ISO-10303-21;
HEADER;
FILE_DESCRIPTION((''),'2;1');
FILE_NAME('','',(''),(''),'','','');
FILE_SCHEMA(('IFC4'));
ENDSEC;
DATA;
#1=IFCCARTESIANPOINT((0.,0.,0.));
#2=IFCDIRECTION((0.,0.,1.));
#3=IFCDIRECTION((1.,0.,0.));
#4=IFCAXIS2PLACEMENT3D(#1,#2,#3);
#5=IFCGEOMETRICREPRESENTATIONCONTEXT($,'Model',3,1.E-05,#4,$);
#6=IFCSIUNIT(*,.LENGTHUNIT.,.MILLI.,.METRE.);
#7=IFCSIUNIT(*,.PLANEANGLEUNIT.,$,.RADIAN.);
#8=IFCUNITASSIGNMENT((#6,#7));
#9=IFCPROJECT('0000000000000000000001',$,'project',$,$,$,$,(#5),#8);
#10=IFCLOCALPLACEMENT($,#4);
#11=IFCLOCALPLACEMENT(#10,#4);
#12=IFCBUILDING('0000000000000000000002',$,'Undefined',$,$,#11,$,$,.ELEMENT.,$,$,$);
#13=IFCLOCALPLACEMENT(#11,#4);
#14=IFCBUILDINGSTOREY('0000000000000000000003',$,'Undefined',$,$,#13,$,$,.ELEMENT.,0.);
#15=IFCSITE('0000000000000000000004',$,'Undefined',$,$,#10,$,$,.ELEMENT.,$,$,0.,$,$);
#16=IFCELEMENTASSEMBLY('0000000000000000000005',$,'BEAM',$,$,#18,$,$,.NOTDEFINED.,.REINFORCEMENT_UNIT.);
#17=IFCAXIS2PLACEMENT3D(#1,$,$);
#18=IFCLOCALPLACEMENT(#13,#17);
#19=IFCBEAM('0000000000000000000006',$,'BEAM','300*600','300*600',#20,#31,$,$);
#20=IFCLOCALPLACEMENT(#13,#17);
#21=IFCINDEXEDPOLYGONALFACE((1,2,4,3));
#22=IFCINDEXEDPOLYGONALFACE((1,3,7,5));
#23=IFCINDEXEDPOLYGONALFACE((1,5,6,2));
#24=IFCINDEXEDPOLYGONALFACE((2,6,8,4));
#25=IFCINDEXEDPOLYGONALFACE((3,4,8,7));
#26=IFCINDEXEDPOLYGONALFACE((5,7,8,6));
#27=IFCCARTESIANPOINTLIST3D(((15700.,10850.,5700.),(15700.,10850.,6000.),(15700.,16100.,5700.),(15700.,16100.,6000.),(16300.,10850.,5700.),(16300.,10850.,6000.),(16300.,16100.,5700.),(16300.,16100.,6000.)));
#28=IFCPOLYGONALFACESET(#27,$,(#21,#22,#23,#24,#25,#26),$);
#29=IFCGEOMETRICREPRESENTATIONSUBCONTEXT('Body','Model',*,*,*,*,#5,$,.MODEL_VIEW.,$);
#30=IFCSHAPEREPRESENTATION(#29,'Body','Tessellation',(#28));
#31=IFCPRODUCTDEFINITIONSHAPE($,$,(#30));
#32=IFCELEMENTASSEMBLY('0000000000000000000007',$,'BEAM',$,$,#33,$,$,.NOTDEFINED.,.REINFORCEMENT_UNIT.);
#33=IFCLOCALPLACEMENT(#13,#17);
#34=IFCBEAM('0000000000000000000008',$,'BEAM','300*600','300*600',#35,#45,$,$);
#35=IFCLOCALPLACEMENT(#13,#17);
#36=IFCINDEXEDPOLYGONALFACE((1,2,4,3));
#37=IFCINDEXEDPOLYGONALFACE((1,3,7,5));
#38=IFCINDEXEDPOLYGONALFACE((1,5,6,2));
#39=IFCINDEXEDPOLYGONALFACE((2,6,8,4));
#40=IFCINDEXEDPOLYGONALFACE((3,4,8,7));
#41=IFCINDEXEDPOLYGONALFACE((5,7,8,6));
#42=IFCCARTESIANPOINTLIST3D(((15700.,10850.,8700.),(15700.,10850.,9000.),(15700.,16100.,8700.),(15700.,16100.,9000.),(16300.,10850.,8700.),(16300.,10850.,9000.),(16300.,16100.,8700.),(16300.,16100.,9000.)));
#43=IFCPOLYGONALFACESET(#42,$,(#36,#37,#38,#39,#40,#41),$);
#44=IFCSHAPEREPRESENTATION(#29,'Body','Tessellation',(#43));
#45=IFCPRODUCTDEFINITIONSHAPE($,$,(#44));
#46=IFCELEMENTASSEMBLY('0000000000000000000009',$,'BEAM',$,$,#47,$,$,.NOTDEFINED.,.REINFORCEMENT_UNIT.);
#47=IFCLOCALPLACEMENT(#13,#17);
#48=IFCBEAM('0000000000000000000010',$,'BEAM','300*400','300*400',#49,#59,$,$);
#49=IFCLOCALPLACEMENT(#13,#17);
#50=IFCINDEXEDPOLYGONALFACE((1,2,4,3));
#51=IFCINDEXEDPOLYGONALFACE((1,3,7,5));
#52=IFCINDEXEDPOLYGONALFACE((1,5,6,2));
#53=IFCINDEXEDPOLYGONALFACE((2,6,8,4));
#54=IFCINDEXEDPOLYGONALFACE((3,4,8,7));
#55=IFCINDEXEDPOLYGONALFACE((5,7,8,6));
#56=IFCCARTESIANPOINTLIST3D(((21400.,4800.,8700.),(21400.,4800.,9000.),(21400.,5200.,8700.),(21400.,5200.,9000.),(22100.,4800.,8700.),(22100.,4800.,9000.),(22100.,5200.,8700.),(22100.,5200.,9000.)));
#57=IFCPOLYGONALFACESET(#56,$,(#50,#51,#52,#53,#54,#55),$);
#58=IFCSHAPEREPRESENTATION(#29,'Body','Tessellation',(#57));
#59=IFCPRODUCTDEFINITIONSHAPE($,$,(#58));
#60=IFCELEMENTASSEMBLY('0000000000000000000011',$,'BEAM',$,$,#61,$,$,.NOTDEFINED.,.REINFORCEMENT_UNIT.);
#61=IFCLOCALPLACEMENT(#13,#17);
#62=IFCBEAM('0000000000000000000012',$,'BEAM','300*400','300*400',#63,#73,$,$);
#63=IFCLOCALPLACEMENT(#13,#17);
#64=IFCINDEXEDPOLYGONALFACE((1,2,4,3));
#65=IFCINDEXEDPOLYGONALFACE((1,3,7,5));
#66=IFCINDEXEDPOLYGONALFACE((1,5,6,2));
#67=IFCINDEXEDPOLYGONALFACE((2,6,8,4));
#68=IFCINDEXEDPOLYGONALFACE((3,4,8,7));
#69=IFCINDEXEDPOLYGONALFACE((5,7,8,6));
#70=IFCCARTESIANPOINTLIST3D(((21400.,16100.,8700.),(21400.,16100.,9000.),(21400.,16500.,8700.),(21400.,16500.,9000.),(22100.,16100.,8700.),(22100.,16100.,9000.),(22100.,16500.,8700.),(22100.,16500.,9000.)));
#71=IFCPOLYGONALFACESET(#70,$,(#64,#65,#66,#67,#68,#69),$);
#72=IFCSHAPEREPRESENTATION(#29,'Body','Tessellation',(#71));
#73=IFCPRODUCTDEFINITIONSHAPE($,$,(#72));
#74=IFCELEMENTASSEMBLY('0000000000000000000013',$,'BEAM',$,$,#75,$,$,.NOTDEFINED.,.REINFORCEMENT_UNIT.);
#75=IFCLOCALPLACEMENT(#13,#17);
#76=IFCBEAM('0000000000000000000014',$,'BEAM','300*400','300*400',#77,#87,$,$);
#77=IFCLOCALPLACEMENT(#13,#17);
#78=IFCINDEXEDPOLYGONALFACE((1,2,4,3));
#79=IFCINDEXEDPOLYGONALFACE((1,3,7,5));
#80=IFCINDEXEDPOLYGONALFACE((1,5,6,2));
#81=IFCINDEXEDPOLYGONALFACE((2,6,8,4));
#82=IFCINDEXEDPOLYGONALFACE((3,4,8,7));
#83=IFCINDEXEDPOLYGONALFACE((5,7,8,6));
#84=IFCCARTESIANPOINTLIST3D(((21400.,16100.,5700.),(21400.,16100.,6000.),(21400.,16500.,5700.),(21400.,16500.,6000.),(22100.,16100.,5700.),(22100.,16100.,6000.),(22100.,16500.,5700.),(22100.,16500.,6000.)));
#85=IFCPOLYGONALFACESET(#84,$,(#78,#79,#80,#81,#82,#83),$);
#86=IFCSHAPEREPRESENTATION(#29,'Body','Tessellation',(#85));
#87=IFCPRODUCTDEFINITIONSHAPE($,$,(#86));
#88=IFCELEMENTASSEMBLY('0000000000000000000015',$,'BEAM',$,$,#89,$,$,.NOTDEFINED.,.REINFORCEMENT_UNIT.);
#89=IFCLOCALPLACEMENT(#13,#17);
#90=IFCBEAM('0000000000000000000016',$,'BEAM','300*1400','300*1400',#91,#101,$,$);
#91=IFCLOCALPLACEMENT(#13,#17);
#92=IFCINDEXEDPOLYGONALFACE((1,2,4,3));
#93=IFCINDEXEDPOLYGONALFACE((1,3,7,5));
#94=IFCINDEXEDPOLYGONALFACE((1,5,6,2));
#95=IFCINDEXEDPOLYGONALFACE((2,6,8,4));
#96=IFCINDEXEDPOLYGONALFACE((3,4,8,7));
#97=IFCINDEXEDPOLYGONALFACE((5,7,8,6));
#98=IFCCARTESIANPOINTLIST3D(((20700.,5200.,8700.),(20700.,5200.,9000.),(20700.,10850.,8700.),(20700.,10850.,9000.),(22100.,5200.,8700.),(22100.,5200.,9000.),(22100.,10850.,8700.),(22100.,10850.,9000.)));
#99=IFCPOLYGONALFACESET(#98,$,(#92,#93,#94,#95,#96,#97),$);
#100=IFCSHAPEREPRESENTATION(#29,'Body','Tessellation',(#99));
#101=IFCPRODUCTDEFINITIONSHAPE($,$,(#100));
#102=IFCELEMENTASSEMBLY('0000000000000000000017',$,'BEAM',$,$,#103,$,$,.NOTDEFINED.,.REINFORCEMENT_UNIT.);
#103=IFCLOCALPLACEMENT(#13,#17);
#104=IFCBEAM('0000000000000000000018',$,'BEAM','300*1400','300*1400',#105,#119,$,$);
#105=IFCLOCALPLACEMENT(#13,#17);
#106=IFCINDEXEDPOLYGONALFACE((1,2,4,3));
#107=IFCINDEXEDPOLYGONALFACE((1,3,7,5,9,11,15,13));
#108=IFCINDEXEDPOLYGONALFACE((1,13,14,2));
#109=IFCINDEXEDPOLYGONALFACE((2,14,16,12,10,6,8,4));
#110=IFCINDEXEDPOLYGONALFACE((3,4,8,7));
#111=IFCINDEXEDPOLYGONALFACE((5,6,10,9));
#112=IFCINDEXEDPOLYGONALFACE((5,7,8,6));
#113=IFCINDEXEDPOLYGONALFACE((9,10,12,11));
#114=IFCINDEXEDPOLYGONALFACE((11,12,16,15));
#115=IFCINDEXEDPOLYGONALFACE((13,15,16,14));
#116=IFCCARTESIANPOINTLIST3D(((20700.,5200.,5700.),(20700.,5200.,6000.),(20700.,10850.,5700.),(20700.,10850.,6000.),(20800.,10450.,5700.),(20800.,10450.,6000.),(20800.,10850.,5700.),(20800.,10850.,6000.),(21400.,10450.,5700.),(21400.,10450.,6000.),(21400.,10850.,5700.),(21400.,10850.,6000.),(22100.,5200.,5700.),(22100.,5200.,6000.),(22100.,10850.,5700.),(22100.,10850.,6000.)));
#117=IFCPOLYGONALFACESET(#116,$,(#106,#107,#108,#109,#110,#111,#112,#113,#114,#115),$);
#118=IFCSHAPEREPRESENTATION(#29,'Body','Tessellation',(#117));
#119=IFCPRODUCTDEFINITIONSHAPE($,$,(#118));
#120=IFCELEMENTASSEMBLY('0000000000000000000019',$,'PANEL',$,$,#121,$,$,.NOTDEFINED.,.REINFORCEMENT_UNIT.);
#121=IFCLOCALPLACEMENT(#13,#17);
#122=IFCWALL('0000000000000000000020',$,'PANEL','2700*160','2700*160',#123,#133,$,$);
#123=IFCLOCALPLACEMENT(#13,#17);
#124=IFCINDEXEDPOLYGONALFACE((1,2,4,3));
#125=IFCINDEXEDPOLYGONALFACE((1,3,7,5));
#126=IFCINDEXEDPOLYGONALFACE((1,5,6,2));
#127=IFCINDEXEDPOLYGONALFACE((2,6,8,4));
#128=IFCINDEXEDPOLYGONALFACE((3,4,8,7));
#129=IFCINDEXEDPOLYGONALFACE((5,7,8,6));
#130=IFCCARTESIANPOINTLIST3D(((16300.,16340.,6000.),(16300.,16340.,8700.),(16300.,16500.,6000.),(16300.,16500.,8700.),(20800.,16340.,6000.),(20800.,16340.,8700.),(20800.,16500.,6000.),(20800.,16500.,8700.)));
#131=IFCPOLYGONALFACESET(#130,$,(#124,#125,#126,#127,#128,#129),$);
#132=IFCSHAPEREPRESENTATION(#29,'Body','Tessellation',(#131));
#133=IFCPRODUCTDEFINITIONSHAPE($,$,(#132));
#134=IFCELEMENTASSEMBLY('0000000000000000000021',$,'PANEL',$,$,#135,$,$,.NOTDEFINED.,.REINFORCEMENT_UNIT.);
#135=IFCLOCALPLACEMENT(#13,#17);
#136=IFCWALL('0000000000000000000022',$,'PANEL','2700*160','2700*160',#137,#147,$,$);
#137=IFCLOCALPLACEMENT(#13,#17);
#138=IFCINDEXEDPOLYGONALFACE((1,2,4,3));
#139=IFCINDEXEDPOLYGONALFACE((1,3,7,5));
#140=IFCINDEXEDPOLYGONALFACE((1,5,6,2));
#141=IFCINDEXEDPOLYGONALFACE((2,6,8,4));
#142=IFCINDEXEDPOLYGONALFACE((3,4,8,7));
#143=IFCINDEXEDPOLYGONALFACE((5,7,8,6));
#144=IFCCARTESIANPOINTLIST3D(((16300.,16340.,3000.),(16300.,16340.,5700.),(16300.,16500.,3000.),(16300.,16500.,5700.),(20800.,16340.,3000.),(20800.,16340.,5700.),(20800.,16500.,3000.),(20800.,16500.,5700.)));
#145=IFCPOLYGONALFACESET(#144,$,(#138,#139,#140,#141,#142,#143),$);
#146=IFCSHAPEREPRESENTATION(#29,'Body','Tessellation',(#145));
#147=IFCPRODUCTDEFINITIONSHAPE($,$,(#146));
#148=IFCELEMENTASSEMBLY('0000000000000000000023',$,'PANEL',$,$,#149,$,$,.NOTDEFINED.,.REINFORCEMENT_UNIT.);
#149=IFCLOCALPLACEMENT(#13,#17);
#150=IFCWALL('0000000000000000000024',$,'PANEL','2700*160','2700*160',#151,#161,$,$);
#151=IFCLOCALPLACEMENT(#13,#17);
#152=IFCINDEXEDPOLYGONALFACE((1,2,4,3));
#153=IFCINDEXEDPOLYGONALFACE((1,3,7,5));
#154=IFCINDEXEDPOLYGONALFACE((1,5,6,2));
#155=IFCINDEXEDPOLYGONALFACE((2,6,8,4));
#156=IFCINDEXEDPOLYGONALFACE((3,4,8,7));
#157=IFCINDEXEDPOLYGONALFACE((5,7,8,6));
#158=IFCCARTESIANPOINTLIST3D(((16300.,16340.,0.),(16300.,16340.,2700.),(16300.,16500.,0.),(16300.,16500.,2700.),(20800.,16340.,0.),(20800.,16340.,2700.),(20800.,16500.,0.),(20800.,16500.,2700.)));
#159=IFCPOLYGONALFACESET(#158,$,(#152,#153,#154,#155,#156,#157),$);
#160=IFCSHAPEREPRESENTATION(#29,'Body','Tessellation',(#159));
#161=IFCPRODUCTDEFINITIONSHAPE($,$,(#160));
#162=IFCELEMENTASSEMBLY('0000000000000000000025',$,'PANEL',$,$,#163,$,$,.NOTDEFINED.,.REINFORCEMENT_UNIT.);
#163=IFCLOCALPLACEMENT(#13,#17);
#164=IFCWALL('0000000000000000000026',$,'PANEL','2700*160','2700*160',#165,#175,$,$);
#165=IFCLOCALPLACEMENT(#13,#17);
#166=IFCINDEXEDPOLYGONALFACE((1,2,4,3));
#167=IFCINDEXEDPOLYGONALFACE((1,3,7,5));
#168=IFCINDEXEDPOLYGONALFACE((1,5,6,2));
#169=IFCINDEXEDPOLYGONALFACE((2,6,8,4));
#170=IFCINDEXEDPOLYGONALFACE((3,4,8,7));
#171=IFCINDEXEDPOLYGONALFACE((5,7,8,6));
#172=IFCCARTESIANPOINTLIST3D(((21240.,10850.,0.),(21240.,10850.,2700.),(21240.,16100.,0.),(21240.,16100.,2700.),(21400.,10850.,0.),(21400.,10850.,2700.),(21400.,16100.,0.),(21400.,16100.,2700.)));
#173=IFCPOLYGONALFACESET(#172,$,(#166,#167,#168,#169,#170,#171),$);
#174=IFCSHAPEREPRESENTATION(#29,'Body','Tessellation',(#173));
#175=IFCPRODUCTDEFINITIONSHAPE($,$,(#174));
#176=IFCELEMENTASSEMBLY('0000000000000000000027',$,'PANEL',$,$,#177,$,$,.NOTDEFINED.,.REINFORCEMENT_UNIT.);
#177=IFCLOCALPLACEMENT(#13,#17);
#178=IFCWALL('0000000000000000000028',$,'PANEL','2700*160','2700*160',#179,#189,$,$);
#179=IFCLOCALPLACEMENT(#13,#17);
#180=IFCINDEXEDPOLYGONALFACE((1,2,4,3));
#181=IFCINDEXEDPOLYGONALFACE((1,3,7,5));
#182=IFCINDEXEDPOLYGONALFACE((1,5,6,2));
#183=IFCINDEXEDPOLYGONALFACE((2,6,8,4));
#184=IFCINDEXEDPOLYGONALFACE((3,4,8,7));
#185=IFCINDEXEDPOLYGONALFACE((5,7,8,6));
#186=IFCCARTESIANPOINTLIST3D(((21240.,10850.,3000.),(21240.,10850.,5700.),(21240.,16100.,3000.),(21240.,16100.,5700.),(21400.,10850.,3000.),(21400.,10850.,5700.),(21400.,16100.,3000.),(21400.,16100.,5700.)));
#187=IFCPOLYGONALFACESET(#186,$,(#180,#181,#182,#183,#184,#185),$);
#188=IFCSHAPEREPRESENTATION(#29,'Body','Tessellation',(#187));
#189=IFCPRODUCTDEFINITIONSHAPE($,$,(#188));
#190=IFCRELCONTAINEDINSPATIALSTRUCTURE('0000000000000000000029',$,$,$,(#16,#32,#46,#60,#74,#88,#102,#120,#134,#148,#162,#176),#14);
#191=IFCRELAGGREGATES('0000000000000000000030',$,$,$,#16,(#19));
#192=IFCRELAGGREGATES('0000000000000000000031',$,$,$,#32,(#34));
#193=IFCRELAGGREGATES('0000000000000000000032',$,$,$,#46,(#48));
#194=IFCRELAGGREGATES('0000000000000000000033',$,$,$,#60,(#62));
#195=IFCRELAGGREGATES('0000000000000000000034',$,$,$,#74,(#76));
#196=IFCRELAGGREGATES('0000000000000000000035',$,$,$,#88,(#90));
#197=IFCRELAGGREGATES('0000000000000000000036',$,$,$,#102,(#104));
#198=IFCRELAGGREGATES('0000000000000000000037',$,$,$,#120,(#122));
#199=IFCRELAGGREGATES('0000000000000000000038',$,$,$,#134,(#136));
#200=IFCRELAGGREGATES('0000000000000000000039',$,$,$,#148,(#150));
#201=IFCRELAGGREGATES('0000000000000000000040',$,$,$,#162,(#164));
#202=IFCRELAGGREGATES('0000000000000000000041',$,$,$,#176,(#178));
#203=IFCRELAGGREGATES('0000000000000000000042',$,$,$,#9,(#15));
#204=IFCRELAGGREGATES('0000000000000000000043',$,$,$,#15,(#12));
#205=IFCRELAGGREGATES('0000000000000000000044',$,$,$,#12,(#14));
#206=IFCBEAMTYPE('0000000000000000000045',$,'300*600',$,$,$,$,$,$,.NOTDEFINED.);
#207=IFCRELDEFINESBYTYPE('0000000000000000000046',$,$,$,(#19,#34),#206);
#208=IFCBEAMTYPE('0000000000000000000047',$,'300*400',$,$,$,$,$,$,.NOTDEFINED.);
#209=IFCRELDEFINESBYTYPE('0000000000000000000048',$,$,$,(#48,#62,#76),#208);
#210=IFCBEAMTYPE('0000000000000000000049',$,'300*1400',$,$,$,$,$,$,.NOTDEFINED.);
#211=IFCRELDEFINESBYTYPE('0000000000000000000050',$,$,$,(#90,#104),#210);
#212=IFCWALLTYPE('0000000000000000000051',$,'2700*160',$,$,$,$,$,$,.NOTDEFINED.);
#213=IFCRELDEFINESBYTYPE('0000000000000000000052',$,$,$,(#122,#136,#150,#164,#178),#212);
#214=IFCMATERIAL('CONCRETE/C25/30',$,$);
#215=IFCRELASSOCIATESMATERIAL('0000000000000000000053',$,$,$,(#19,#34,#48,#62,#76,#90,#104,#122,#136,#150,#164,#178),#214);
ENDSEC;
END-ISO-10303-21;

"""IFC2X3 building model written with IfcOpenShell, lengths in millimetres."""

from ifc_helpers import new_model, si_unit, frame, frame_2d, origin_with_axes, origin_2d_with_axis, place, context, subcontext, project, spatial, rectangle, extrude, boolean, material, type_object, element, aggregate, save


model = new_model("IFC2X3")

# Units and contexts
model_context = context("Model", 3, precision=1e-05, world=origin_with_axes())
body_context = subcontext(model_context, "Body", "Model", "MODEL_VIEW")
ifc_project = project(units=[si_unit("LENGTHUNIT", "METRE", prefix="MILLI"), si_unit("PLANEANGLEUNIT", "RADIAN")], contexts=[model_context])

# Site, building, storey
site_placement = place(None, origin_with_axes())
site = spatial("IfcSite", under=ifc_project, at=site_placement, Name="Undefined", CompositionType="ELEMENT", RefElevation=0.0)
building_placement = place(site_placement, origin_with_axes())
building = spatial("IfcBuilding", under=site, at=building_placement, Name="Undefined", CompositionType="ELEMENT")
storey_placement = place(building_placement, origin_with_axes())
storey = spatial("IfcBuildingStorey", under=building, at=storey_placement, Name="Undefined", CompositionType="ELEMENT", Elevation=0.0)

# Shared definitions
ifc_material = material(Name="CONCRETE/C25/30")

# Element assemblies, beams
beam_type_1 = type_object("IfcBeamType", Name="300*600", PredefinedType="NOTDEFINED")
assembly_1_placement = place(storey_placement, origin_with_axes())
assembly_1 = element("IfcElementAssembly", 1, at=assembly_1_placement, inside=storey, Name="BEAM", AssemblyPlace="NOTDEFINED", PredefinedType="REINFORCEMENT_UNIT")
beam_1_placement = place(assembly_1_placement, frame((16000.0, 16300.0, 5850.0), z_axis=(0.0, 0.0, 1.0), x_axis=(0.0, -1.0, 0.0)))
beam_1 = element("IfcBeam", 2, at=beam_1_placement, type_object=beam_type_1, material=ifc_material, Name="BEAM", Description="300*600", ObjectType="300*600", context=body_context, shape_type="SweptSolid", body=[
    extrude(rectangle(XDim=600.0, YDim=300.0, at=origin_2d_with_axis()), frame((5450.0, 0.0, 0.0), z_axis=(-1.0, 0.0, 0.0), x_axis=(0.0, -1.0, 0.0)), (0.0, 0.0, 1.0), 5250.0),
])
aggregate(assembly_1, [beam_1])
assembly_2_placement = place(storey_placement, origin_with_axes())
assembly_2 = element("IfcElementAssembly", 3, at=assembly_2_placement, inside=storey, Name="BEAM", AssemblyPlace="NOTDEFINED", PredefinedType="REINFORCEMENT_UNIT")
beam_2_placement = place(assembly_2_placement, frame((16000.0, 16300.0, 8850.0), z_axis=(0.0, 0.0, 1.0), x_axis=(0.0, -1.0, 0.0)))
beam_2 = element("IfcBeam", 4, at=beam_2_placement, type_object=beam_type_1, material=ifc_material, Name="BEAM", Description="300*600", ObjectType="300*600", context=body_context, shape_type="SweptSolid", body=[
    extrude(rectangle(XDim=600.0, YDim=300.0, at=origin_2d_with_axis()), frame((5450.0, 0.0, 0.0), z_axis=(-1.0, 0.0, 0.0), x_axis=(0.0, -1.0, 0.0)), (0.0, 0.0, 1.0), 5250.0),
])
aggregate(assembly_2, [beam_2])
beam_type_2 = type_object("IfcBeamType", Name="300*400", PredefinedType="NOTDEFINED")
assembly_3_placement = place(storey_placement, origin_with_axes())
assembly_3 = element("IfcElementAssembly", 5, at=assembly_3_placement, inside=storey, Name="BEAM", AssemblyPlace="NOTDEFINED", PredefinedType="REINFORCEMENT_UNIT")
beam_3_placement = place(assembly_3_placement, frame((21400.0, 5000.0, 8850.0), z_axis=(0.0, 0.0, 1.0), x_axis=(1.0, 0.0, 0.0)))
beam_3 = element("IfcBeam", 6, at=beam_3_placement, type_object=beam_type_2, material=ifc_material, Name="BEAM", Description="300*400", ObjectType="300*400", context=body_context, shape_type="SweptSolid", body=[
    extrude(rectangle(XDim=400.0, YDim=300.0, at=origin_2d_with_axis()), frame((700.0, 0.0, 0.0), z_axis=(-1.0, 0.0, 0.0), x_axis=(0.0, -1.0, 0.0)), (0.0, 0.0, 1.0), 700.0),
])
aggregate(assembly_3, [beam_3])
assembly_4_placement = place(storey_placement, origin_with_axes())
assembly_4 = element("IfcElementAssembly", 7, at=assembly_4_placement, inside=storey, Name="BEAM", AssemblyPlace="NOTDEFINED", PredefinedType="REINFORCEMENT_UNIT")
beam_4_placement = place(assembly_4_placement, frame((21400.0, 16300.0, 8850.0), z_axis=(0.0, 0.0, 1.0), x_axis=(1.0, 0.0, 0.0)))
beam_4 = element("IfcBeam", 8, at=beam_4_placement, type_object=beam_type_2, material=ifc_material, Name="BEAM", Description="300*400", ObjectType="300*400", context=body_context, shape_type="SweptSolid", body=[
    extrude(rectangle(XDim=400.0, YDim=300.0, at=origin_2d_with_axis()), frame((700.0, 0.0, 0.0), z_axis=(-1.0, 0.0, 0.0), x_axis=(0.0, -1.0, 0.0)), (0.0, 0.0, 1.0), 700.0),
])
aggregate(assembly_4, [beam_4])
assembly_5_placement = place(storey_placement, origin_with_axes())
assembly_5 = element("IfcElementAssembly", 9, at=assembly_5_placement, inside=storey, Name="BEAM", AssemblyPlace="NOTDEFINED", PredefinedType="REINFORCEMENT_UNIT")
beam_5_placement = place(assembly_5_placement, frame((21400.0, 16300.0, 5850.0), z_axis=(0.0, 0.0, 1.0), x_axis=(1.0, 0.0, 0.0)))
beam_5 = element("IfcBeam", 10, at=beam_5_placement, type_object=beam_type_2, material=ifc_material, Name="BEAM", Description="300*400", ObjectType="300*400", context=body_context, shape_type="SweptSolid", body=[
    extrude(rectangle(XDim=400.0, YDim=300.0, at=origin_2d_with_axis()), frame((700.0, 0.0, 0.0), z_axis=(-1.0, 0.0, 0.0), x_axis=(0.0, -1.0, 0.0)), (0.0, 0.0, 1.0), 700.0),
])
aggregate(assembly_5, [beam_5])
assembly_6_placement = place(storey_placement, origin_with_axes())
assembly_6 = element("IfcElementAssembly", 11, at=assembly_6_placement, inside=storey, Name="BEAM", AssemblyPlace="NOTDEFINED", PredefinedType="REINFORCEMENT_UNIT")
beam_type_3 = type_object("IfcBeamType", Name="300*1400", PredefinedType="NOTDEFINED")
beam_6_placement = place(assembly_6_placement, frame((21400.0, 5200.0, 8850.0), z_axis=(0.0, 0.0, 1.0), x_axis=(0.0, 1.0, 0.0)))
beam_6 = element("IfcBeam", 12, at=beam_6_placement, type_object=beam_type_3, material=ifc_material, Name="BEAM", Description="300*1400", ObjectType="300*1400", context=body_context, shape_type="SweptSolid", body=[
    extrude(rectangle(XDim=1400.0, YDim=300.0, at=origin_2d_with_axis()), frame((5650.0, 0.0, 0.0), z_axis=(-1.0, 0.0, 0.0), x_axis=(0.0, -1.0, 0.0)), (0.0, 0.0, 1.0), 5650.0),
])
aggregate(assembly_6, [beam_6])
assembly_7_placement = place(storey_placement, origin_with_axes())
assembly_7 = element("IfcElementAssembly", 13, at=assembly_7_placement, inside=storey, Name="BEAM", AssemblyPlace="NOTDEFINED", PredefinedType="REINFORCEMENT_UNIT")
beam_7_placement = place(assembly_7_placement, frame((21400.0, 5200.0, 5850.0), z_axis=(0.0, 0.0, 1.0), x_axis=(0.0, 1.0, 0.0)))
beam_7 = element("IfcBeam", 14, at=beam_7_placement, type_object=beam_type_3, material=ifc_material, Name="BEAM", Description="300*1400", ObjectType="300*1400", context=body_context, shape_type="CSG", body=[
    boolean("DIFFERENCE", extrude(rectangle(XDim=1400.0, YDim=300.0, at=origin_2d_with_axis()), frame((5650.0, 0.0, 0.0), z_axis=(-1.0, 0.0, 0.0), x_axis=(0.0, -1.0, 0.0)), (0.0, 0.0, 1.0), 5650.0), extrude(rectangle(XDim=600.0, YDim=400.0, at=origin_2d_with_axis()), frame((5450.0, 300.0, 150.0), z_axis=(0.0, 0.0, -1.0), x_axis=(0.0, 1.0, 0.0)), (0.0, 0.0, 1.0), 3000.0)),
])
aggregate(assembly_7, [beam_7])

# Element assemblies, walls
assembly_8_placement = place(storey_placement, origin_with_axes())
assembly_8 = element("IfcElementAssembly", 15, at=assembly_8_placement, inside=storey, Name="PANEL", AssemblyPlace="NOTDEFINED", PredefinedType="REINFORCEMENT_UNIT")
wall_type = type_object("IfcWallType", Name="2700*160", PredefinedType="NOTDEFINED")
wall_1_placement = place(assembly_8_placement, frame((16300.0, 16420.0, 6000.0), z_axis=(0.0, 0.0, 1.0), x_axis=(1.0, 0.0, 0.0)))
wall_1 = element("IfcWall", 16, at=wall_1_placement, type_object=wall_type, material=ifc_material, Name="PANEL", Description="2700*160", ObjectType="2700*160", context=body_context, shape_type="SweptSolid", body=[
    extrude(rectangle(XDim=4500.0, YDim=160.0, at=frame_2d((0.0, 2250.0), x_axis=(0.0, -1.0))), frame((0.0, 0.0, 0.0), z_axis=(0.0, 0.0, 1.0), x_axis=(0.0, -1.0, 0.0)), (0.0, 0.0, 1.0), 2700.0),
])
aggregate(assembly_8, [wall_1])
assembly_9_placement = place(storey_placement, origin_with_axes())
assembly_9 = element("IfcElementAssembly", 17, at=assembly_9_placement, inside=storey, Name="PANEL", AssemblyPlace="NOTDEFINED", PredefinedType="REINFORCEMENT_UNIT")
wall_2_placement = place(assembly_9_placement, frame((16300.0, 16420.0, 3000.0), z_axis=(0.0, 0.0, 1.0), x_axis=(1.0, 0.0, 0.0)))
wall_2 = element("IfcWall", 18, at=wall_2_placement, type_object=wall_type, material=ifc_material, Name="PANEL", Description="2700*160", ObjectType="2700*160", context=body_context, shape_type="SweptSolid", body=[
    extrude(rectangle(XDim=4500.0, YDim=160.0, at=frame_2d((0.0, 2250.0), x_axis=(0.0, -1.0))), frame((0.0, 0.0, 0.0), z_axis=(0.0, 0.0, 1.0), x_axis=(0.0, -1.0, 0.0)), (0.0, 0.0, 1.0), 2700.0),
])
aggregate(assembly_9, [wall_2])
assembly_10_placement = place(storey_placement, origin_with_axes())
assembly_10 = element("IfcElementAssembly", 19, at=assembly_10_placement, inside=storey, Name="PANEL", AssemblyPlace="NOTDEFINED", PredefinedType="REINFORCEMENT_UNIT")
wall_3_placement = place(assembly_10_placement, frame((20800.0, 16420.0, 0.0), z_axis=(0.0, 0.0, 1.0), x_axis=(-1.0, 0.0, 0.0)))
wall_3 = element("IfcWall", 20, at=wall_3_placement, type_object=wall_type, material=ifc_material, Name="PANEL", Description="2700*160", ObjectType="2700*160", context=body_context, shape_type="SweptSolid", body=[
    extrude(rectangle(XDim=4500.0, YDim=160.0, at=frame_2d((0.0, 2250.0), x_axis=(0.0, -1.0))), frame((0.0, 0.0, 0.0), z_axis=(0.0, 0.0, 1.0), x_axis=(0.0, -1.0, 0.0)), (0.0, 0.0, 1.0), 2700.0),
])
aggregate(assembly_10, [wall_3])
assembly_11_placement = place(storey_placement, origin_with_axes())
assembly_11 = element("IfcElementAssembly", 21, at=assembly_11_placement, inside=storey, Name="PANEL", AssemblyPlace="NOTDEFINED", PredefinedType="REINFORCEMENT_UNIT")
wall_4_placement = place(assembly_11_placement, frame((21320.0, 16100.0, 0.0), z_axis=(0.0, 0.0, 1.0), x_axis=(0.0, -1.0, 0.0)))
wall_4 = element("IfcWall", 22, at=wall_4_placement, type_object=wall_type, material=ifc_material, Name="PANEL", Description="2700*160", ObjectType="2700*160", context=body_context, shape_type="SweptSolid", body=[
    extrude(rectangle(XDim=5250.0, YDim=160.0, at=frame_2d((0.0, 2625.0), x_axis=(0.0, -1.0))), frame((0.0, 0.0, 0.0), z_axis=(0.0, 0.0, 1.0), x_axis=(0.0, -1.0, 0.0)), (0.0, 0.0, 1.0), 2700.0),
])
aggregate(assembly_11, [wall_4])
assembly_12_placement = place(storey_placement, origin_with_axes())
assembly_12 = element("IfcElementAssembly", 23, at=assembly_12_placement, inside=storey, Name="PANEL", AssemblyPlace="NOTDEFINED", PredefinedType="REINFORCEMENT_UNIT")
wall_5_placement = place(assembly_12_placement, frame((21320.0, 16100.0, 3000.0), z_axis=(0.0, 0.0, 1.0), x_axis=(0.0, -1.0, 0.0)))
wall_5 = element("IfcWall", 24, at=wall_5_placement, type_object=wall_type, material=ifc_material, Name="PANEL", Description="2700*160", ObjectType="2700*160", context=body_context, shape_type="SweptSolid", body=[
    extrude(rectangle(XDim=5250.0, YDim=160.0, at=frame_2d((0.0, 2625.0), x_axis=(0.0, -1.0))), frame((0.0, 0.0, 0.0), z_axis=(0.0, 0.0, 1.0), x_axis=(0.0, -1.0, 0.0)), (0.0, 0.0, 1.0), 2700.0),
])
aggregate(assembly_12, [wall_5])

save(model, "model.ifc")
